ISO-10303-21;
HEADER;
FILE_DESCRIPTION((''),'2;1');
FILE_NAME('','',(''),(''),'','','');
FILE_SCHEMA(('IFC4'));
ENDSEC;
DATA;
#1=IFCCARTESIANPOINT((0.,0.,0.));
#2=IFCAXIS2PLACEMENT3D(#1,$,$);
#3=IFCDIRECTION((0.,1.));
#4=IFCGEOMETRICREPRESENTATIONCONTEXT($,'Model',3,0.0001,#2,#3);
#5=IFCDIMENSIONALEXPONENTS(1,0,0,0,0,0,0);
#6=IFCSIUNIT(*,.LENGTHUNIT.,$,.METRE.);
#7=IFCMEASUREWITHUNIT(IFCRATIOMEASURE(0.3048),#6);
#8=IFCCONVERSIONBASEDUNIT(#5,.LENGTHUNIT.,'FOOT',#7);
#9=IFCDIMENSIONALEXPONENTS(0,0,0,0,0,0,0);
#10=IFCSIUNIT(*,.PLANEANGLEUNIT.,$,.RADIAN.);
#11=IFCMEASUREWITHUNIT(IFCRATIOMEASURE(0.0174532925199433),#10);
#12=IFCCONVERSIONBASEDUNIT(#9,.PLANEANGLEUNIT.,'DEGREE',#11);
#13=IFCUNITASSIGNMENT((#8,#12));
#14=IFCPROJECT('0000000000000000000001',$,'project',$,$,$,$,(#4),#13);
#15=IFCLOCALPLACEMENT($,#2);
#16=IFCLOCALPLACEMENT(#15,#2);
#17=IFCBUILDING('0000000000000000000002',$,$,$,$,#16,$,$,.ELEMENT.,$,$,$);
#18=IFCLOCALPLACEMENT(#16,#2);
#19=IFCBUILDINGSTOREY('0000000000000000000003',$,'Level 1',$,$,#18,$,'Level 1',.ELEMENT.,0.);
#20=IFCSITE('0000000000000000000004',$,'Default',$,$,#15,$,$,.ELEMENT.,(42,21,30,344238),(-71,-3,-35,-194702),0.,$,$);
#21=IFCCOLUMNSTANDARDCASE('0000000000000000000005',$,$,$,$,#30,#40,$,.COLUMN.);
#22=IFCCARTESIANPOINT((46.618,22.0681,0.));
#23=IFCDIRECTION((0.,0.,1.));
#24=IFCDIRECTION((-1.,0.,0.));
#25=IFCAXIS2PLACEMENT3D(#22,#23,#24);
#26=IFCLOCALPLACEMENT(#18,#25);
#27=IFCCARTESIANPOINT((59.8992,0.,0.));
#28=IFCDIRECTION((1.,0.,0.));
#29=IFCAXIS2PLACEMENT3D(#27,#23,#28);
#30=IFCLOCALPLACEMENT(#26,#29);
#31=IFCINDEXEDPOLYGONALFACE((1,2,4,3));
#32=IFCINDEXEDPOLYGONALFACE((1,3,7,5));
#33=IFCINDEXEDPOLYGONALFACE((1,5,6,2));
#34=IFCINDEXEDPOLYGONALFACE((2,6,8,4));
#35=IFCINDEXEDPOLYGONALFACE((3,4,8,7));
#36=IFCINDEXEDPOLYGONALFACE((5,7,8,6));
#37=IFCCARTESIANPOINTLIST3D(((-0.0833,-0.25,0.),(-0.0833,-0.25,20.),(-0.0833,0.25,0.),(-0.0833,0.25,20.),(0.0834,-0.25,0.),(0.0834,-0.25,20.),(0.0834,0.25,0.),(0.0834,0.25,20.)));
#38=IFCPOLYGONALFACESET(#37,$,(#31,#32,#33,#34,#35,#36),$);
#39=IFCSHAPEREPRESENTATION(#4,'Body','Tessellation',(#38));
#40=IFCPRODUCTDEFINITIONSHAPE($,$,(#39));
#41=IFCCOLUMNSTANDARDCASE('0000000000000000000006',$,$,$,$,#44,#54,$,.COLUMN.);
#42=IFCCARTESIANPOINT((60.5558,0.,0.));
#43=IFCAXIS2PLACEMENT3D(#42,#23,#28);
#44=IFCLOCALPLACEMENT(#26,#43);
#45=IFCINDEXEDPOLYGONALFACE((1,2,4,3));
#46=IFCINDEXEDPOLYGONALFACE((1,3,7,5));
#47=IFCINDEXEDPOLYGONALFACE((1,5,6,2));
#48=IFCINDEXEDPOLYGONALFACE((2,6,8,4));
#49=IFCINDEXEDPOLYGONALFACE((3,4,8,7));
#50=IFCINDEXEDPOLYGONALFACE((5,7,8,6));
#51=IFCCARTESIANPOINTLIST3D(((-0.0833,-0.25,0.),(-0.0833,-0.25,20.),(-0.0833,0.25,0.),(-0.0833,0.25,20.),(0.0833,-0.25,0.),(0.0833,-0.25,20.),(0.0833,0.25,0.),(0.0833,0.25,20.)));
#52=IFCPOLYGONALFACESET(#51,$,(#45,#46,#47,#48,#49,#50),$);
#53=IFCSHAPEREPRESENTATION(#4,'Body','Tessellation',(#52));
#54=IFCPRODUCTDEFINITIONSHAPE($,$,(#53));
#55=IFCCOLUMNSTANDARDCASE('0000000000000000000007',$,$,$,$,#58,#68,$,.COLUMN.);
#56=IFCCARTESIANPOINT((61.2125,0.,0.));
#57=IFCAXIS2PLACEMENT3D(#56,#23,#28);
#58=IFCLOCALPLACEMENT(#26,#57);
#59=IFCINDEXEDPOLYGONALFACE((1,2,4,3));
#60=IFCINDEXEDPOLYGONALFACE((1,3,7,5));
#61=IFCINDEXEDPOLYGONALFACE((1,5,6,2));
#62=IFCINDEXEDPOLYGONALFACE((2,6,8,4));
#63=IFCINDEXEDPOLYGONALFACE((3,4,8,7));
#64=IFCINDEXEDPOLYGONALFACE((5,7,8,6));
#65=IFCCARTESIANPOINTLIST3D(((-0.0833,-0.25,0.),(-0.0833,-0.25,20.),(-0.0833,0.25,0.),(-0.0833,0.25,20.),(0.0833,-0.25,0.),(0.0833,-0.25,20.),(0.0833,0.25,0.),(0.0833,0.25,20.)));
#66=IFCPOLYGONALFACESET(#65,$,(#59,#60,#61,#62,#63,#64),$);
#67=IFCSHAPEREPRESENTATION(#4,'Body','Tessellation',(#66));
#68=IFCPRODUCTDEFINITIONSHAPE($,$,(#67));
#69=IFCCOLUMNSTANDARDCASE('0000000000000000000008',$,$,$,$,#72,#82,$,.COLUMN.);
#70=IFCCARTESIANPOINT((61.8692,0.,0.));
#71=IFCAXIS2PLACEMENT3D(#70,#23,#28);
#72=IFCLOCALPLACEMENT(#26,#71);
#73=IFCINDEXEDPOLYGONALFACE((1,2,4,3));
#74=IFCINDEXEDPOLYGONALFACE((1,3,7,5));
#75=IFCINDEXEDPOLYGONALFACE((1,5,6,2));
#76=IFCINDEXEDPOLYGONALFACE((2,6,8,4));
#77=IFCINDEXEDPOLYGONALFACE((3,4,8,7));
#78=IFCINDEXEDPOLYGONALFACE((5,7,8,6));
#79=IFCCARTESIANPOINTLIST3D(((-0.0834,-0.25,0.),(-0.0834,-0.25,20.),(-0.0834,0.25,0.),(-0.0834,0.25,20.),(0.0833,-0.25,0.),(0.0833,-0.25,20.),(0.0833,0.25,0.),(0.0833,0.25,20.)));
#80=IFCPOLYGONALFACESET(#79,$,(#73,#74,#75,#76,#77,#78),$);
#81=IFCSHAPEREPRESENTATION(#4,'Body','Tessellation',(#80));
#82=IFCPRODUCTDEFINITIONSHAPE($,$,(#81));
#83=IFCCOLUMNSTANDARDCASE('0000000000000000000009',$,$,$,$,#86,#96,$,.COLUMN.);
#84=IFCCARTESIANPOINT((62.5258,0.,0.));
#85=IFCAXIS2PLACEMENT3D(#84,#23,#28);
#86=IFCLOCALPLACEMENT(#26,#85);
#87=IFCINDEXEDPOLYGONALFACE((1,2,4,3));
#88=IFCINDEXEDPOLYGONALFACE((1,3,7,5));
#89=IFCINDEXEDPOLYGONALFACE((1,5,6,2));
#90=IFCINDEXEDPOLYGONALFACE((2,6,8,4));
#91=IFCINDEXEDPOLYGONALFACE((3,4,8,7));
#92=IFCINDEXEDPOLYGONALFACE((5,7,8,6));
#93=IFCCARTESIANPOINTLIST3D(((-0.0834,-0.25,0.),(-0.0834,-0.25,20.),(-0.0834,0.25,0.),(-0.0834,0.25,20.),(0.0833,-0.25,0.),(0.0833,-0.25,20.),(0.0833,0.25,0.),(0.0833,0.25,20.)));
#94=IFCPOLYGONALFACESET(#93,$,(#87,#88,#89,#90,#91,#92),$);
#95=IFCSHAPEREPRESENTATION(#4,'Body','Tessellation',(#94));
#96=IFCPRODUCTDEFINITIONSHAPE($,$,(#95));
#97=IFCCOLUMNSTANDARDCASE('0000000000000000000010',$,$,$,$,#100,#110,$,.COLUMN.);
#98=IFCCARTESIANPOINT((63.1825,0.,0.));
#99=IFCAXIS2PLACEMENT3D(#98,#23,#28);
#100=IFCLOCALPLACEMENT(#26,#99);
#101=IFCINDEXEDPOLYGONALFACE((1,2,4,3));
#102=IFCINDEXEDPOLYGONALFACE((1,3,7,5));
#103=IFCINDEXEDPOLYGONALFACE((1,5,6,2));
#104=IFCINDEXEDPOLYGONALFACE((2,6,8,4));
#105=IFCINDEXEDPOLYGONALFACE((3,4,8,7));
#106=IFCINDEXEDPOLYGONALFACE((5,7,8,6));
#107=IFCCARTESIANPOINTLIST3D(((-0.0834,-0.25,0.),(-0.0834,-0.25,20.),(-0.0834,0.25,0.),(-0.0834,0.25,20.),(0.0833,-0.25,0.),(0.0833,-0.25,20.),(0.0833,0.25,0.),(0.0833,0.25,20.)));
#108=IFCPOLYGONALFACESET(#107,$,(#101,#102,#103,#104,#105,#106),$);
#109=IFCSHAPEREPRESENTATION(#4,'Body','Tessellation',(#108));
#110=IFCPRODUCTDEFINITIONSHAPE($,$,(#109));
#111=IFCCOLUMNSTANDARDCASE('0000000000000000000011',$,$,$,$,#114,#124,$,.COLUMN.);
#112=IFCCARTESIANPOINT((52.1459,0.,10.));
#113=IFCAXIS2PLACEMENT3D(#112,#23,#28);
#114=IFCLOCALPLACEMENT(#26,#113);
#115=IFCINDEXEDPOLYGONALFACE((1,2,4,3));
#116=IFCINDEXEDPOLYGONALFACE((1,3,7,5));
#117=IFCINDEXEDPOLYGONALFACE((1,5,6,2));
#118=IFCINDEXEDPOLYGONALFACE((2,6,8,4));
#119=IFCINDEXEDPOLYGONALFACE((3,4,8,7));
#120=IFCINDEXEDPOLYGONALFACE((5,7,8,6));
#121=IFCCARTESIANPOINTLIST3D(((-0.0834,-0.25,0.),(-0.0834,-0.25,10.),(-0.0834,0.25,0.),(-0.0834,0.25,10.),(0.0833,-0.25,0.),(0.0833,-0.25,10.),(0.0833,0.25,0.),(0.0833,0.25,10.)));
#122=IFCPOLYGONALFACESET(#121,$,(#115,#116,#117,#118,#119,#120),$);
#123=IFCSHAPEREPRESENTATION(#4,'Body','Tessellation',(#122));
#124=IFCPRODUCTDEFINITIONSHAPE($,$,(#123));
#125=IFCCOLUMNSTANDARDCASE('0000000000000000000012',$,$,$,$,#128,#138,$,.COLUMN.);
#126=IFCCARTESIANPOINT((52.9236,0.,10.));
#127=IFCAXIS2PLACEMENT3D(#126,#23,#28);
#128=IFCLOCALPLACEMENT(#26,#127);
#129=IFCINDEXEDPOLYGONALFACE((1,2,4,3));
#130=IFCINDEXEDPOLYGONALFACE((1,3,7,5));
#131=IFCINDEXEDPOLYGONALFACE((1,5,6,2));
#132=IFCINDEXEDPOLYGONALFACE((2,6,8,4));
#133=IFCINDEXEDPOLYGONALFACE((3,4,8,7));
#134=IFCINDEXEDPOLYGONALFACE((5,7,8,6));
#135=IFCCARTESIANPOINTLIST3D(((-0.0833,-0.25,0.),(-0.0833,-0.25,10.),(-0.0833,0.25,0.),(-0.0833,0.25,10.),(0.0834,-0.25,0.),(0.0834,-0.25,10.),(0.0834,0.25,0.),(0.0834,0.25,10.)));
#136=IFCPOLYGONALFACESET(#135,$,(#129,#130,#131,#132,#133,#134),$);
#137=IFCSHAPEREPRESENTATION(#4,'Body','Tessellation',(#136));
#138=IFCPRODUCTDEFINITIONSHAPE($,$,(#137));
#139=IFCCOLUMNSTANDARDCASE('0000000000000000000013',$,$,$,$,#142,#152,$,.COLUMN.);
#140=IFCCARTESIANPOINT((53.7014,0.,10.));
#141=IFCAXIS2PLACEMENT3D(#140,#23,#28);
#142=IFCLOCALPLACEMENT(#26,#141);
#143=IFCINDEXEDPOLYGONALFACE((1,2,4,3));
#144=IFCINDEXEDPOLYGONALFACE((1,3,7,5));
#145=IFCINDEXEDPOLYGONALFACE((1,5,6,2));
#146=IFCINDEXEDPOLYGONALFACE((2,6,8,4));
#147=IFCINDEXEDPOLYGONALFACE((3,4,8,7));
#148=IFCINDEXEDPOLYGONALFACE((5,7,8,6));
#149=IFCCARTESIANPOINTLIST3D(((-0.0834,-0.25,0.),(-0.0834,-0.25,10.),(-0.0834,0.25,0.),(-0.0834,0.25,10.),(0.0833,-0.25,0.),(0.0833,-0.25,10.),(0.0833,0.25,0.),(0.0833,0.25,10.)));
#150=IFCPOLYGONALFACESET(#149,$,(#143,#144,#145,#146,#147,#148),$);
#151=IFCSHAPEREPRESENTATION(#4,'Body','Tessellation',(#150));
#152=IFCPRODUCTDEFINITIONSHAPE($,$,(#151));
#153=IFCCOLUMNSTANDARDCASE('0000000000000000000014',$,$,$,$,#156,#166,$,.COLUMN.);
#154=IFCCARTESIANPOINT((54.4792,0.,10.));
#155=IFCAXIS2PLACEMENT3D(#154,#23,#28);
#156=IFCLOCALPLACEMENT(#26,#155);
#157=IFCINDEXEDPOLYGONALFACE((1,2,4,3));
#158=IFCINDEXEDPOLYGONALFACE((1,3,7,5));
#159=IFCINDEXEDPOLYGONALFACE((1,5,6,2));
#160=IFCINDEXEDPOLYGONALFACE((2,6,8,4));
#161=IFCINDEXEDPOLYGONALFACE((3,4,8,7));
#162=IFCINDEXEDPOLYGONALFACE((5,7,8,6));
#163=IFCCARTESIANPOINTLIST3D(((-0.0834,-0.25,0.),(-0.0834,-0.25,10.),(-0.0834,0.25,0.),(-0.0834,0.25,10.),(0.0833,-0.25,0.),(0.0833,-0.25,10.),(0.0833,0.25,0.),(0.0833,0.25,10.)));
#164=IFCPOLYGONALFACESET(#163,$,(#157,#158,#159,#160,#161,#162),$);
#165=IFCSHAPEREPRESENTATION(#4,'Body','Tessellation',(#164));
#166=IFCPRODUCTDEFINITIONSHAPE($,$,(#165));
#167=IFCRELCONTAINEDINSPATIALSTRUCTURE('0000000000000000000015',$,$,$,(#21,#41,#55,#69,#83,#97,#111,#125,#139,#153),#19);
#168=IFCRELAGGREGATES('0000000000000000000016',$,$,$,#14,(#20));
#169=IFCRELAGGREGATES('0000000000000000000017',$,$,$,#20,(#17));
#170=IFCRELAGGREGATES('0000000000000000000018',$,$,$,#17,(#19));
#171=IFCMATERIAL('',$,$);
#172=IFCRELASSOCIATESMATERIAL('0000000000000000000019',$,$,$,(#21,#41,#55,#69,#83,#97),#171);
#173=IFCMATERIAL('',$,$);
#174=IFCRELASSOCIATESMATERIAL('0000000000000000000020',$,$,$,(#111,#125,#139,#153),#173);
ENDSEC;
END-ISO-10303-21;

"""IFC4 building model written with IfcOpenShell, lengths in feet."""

from ifc_helpers import new_model, entity, si_unit, converted_unit, direction, frame, origin, place, context, project, spatial, rectangle, extrude, material, element, save


model = new_model("IFC4")

# Units and contexts
model_context = context("Model", 3, precision=0.0001, world=origin(), true_north=direction((0.0, 1.0)))
ifc_project = project(units=[converted_unit("LENGTHUNIT", "FOOT", entity("IfcRatioMeasure", 0.3048), si_unit("LENGTHUNIT", "METRE"), dimensions=[1, 0, 0, 0, 0, 0, 0]), converted_unit("PLANEANGLEUNIT", "DEGREE", entity("IfcRatioMeasure", 0.0174532925199433), si_unit("PLANEANGLEUNIT", "RADIAN"), dimensions=[0, 0, 0, 0, 0, 0, 0])], contexts=[model_context])

# Site, building, storey
site_placement = place(None, origin())
site = spatial("IfcSite", under=ifc_project, at=site_placement, Name="Default", CompositionType="ELEMENT", RefLatitude=(42, 21, 30, 344238), RefLongitude=(-71, -3, -35, -194702), RefElevation=0.0)
building_placement = place(site_placement, origin())
building = spatial("IfcBuilding", under=site, at=building_placement, CompositionType="ELEMENT")
storey_placement = place(building_placement, origin())
storey = spatial("IfcBuildingStorey", under=building, at=storey_placement, Name="Level 1", LongName="Level 1", CompositionType="ELEMENT", Elevation=0.0)

# Columns
ifc_material_1 = material(Name="")
placement = place(storey_placement, frame((46.618, 22.0681, 0.0), z_axis=(0.0, 0.0, 1.0), x_axis=(-1.0, 0.0, 0.0)))
for number, where, z_axis, x_axis in (
    (1, (59.8992, 0.0, 0.0), (0.0, 0.0, 1.0), (1.0, 0.0, 0.0)),
    (2, (60.5558, 0.0, 0.0), (0.0, 0.0, 1.0), (1.0, 0.0, 0.0)),
    (3, (61.2125, 0.0, 0.0), (0.0, 0.0, 1.0), (1.0, 0.0, 0.0)),
    (4, (61.8692, 0.0, 0.0), (0.0, 0.0, 1.0), (1.0, 0.0, 0.0)),
    (5, (62.5258, 0.0, 0.0), (0.0, 0.0, 1.0), (1.0, 0.0, 0.0)),
    (6, (63.1825, 0.0, 0.0), (0.0, 0.0, 1.0), (1.0, 0.0, 0.0)),
):
    element("IfcColumnStandardCase", number, at=place(placement, frame(where, z_axis=z_axis, x_axis=x_axis)), inside=storey, material=ifc_material_1, PredefinedType="COLUMN", context=model_context, shape_type="SweptSolid", body=[
        extrude(rectangle(XDim=0.1667, YDim=0.5), origin(), (0.0, 0.0, 1.0), 20.0),
    ])
ifc_material_2 = material(Name="")
for number, where, z_axis, x_axis in (
    (7, (52.1459, 0.0, 10.0), (0.0, 0.0, 1.0), (1.0, 0.0, 0.0)),
    (8, (52.9236, 0.0, 10.0), (0.0, 0.0, 1.0), (1.0, 0.0, 0.0)),
    (9, (53.7014, 0.0, 10.0), (0.0, 0.0, 1.0), (1.0, 0.0, 0.0)),
    (10, (54.4792, 0.0, 10.0), (0.0, 0.0, 1.0), (1.0, 0.0, 0.0)),
):
    element("IfcColumnStandardCase", number, at=place(placement, frame(where, z_axis=z_axis, x_axis=x_axis)), inside=storey, material=ifc_material_2, PredefinedType="COLUMN", context=model_context, shape_type="SweptSolid", body=[
        extrude(rectangle(XDim=0.1667, YDim=0.5), origin(), (0.0, 0.0, 1.0), 10.0),
    ])

save(model, "model.ifc")
